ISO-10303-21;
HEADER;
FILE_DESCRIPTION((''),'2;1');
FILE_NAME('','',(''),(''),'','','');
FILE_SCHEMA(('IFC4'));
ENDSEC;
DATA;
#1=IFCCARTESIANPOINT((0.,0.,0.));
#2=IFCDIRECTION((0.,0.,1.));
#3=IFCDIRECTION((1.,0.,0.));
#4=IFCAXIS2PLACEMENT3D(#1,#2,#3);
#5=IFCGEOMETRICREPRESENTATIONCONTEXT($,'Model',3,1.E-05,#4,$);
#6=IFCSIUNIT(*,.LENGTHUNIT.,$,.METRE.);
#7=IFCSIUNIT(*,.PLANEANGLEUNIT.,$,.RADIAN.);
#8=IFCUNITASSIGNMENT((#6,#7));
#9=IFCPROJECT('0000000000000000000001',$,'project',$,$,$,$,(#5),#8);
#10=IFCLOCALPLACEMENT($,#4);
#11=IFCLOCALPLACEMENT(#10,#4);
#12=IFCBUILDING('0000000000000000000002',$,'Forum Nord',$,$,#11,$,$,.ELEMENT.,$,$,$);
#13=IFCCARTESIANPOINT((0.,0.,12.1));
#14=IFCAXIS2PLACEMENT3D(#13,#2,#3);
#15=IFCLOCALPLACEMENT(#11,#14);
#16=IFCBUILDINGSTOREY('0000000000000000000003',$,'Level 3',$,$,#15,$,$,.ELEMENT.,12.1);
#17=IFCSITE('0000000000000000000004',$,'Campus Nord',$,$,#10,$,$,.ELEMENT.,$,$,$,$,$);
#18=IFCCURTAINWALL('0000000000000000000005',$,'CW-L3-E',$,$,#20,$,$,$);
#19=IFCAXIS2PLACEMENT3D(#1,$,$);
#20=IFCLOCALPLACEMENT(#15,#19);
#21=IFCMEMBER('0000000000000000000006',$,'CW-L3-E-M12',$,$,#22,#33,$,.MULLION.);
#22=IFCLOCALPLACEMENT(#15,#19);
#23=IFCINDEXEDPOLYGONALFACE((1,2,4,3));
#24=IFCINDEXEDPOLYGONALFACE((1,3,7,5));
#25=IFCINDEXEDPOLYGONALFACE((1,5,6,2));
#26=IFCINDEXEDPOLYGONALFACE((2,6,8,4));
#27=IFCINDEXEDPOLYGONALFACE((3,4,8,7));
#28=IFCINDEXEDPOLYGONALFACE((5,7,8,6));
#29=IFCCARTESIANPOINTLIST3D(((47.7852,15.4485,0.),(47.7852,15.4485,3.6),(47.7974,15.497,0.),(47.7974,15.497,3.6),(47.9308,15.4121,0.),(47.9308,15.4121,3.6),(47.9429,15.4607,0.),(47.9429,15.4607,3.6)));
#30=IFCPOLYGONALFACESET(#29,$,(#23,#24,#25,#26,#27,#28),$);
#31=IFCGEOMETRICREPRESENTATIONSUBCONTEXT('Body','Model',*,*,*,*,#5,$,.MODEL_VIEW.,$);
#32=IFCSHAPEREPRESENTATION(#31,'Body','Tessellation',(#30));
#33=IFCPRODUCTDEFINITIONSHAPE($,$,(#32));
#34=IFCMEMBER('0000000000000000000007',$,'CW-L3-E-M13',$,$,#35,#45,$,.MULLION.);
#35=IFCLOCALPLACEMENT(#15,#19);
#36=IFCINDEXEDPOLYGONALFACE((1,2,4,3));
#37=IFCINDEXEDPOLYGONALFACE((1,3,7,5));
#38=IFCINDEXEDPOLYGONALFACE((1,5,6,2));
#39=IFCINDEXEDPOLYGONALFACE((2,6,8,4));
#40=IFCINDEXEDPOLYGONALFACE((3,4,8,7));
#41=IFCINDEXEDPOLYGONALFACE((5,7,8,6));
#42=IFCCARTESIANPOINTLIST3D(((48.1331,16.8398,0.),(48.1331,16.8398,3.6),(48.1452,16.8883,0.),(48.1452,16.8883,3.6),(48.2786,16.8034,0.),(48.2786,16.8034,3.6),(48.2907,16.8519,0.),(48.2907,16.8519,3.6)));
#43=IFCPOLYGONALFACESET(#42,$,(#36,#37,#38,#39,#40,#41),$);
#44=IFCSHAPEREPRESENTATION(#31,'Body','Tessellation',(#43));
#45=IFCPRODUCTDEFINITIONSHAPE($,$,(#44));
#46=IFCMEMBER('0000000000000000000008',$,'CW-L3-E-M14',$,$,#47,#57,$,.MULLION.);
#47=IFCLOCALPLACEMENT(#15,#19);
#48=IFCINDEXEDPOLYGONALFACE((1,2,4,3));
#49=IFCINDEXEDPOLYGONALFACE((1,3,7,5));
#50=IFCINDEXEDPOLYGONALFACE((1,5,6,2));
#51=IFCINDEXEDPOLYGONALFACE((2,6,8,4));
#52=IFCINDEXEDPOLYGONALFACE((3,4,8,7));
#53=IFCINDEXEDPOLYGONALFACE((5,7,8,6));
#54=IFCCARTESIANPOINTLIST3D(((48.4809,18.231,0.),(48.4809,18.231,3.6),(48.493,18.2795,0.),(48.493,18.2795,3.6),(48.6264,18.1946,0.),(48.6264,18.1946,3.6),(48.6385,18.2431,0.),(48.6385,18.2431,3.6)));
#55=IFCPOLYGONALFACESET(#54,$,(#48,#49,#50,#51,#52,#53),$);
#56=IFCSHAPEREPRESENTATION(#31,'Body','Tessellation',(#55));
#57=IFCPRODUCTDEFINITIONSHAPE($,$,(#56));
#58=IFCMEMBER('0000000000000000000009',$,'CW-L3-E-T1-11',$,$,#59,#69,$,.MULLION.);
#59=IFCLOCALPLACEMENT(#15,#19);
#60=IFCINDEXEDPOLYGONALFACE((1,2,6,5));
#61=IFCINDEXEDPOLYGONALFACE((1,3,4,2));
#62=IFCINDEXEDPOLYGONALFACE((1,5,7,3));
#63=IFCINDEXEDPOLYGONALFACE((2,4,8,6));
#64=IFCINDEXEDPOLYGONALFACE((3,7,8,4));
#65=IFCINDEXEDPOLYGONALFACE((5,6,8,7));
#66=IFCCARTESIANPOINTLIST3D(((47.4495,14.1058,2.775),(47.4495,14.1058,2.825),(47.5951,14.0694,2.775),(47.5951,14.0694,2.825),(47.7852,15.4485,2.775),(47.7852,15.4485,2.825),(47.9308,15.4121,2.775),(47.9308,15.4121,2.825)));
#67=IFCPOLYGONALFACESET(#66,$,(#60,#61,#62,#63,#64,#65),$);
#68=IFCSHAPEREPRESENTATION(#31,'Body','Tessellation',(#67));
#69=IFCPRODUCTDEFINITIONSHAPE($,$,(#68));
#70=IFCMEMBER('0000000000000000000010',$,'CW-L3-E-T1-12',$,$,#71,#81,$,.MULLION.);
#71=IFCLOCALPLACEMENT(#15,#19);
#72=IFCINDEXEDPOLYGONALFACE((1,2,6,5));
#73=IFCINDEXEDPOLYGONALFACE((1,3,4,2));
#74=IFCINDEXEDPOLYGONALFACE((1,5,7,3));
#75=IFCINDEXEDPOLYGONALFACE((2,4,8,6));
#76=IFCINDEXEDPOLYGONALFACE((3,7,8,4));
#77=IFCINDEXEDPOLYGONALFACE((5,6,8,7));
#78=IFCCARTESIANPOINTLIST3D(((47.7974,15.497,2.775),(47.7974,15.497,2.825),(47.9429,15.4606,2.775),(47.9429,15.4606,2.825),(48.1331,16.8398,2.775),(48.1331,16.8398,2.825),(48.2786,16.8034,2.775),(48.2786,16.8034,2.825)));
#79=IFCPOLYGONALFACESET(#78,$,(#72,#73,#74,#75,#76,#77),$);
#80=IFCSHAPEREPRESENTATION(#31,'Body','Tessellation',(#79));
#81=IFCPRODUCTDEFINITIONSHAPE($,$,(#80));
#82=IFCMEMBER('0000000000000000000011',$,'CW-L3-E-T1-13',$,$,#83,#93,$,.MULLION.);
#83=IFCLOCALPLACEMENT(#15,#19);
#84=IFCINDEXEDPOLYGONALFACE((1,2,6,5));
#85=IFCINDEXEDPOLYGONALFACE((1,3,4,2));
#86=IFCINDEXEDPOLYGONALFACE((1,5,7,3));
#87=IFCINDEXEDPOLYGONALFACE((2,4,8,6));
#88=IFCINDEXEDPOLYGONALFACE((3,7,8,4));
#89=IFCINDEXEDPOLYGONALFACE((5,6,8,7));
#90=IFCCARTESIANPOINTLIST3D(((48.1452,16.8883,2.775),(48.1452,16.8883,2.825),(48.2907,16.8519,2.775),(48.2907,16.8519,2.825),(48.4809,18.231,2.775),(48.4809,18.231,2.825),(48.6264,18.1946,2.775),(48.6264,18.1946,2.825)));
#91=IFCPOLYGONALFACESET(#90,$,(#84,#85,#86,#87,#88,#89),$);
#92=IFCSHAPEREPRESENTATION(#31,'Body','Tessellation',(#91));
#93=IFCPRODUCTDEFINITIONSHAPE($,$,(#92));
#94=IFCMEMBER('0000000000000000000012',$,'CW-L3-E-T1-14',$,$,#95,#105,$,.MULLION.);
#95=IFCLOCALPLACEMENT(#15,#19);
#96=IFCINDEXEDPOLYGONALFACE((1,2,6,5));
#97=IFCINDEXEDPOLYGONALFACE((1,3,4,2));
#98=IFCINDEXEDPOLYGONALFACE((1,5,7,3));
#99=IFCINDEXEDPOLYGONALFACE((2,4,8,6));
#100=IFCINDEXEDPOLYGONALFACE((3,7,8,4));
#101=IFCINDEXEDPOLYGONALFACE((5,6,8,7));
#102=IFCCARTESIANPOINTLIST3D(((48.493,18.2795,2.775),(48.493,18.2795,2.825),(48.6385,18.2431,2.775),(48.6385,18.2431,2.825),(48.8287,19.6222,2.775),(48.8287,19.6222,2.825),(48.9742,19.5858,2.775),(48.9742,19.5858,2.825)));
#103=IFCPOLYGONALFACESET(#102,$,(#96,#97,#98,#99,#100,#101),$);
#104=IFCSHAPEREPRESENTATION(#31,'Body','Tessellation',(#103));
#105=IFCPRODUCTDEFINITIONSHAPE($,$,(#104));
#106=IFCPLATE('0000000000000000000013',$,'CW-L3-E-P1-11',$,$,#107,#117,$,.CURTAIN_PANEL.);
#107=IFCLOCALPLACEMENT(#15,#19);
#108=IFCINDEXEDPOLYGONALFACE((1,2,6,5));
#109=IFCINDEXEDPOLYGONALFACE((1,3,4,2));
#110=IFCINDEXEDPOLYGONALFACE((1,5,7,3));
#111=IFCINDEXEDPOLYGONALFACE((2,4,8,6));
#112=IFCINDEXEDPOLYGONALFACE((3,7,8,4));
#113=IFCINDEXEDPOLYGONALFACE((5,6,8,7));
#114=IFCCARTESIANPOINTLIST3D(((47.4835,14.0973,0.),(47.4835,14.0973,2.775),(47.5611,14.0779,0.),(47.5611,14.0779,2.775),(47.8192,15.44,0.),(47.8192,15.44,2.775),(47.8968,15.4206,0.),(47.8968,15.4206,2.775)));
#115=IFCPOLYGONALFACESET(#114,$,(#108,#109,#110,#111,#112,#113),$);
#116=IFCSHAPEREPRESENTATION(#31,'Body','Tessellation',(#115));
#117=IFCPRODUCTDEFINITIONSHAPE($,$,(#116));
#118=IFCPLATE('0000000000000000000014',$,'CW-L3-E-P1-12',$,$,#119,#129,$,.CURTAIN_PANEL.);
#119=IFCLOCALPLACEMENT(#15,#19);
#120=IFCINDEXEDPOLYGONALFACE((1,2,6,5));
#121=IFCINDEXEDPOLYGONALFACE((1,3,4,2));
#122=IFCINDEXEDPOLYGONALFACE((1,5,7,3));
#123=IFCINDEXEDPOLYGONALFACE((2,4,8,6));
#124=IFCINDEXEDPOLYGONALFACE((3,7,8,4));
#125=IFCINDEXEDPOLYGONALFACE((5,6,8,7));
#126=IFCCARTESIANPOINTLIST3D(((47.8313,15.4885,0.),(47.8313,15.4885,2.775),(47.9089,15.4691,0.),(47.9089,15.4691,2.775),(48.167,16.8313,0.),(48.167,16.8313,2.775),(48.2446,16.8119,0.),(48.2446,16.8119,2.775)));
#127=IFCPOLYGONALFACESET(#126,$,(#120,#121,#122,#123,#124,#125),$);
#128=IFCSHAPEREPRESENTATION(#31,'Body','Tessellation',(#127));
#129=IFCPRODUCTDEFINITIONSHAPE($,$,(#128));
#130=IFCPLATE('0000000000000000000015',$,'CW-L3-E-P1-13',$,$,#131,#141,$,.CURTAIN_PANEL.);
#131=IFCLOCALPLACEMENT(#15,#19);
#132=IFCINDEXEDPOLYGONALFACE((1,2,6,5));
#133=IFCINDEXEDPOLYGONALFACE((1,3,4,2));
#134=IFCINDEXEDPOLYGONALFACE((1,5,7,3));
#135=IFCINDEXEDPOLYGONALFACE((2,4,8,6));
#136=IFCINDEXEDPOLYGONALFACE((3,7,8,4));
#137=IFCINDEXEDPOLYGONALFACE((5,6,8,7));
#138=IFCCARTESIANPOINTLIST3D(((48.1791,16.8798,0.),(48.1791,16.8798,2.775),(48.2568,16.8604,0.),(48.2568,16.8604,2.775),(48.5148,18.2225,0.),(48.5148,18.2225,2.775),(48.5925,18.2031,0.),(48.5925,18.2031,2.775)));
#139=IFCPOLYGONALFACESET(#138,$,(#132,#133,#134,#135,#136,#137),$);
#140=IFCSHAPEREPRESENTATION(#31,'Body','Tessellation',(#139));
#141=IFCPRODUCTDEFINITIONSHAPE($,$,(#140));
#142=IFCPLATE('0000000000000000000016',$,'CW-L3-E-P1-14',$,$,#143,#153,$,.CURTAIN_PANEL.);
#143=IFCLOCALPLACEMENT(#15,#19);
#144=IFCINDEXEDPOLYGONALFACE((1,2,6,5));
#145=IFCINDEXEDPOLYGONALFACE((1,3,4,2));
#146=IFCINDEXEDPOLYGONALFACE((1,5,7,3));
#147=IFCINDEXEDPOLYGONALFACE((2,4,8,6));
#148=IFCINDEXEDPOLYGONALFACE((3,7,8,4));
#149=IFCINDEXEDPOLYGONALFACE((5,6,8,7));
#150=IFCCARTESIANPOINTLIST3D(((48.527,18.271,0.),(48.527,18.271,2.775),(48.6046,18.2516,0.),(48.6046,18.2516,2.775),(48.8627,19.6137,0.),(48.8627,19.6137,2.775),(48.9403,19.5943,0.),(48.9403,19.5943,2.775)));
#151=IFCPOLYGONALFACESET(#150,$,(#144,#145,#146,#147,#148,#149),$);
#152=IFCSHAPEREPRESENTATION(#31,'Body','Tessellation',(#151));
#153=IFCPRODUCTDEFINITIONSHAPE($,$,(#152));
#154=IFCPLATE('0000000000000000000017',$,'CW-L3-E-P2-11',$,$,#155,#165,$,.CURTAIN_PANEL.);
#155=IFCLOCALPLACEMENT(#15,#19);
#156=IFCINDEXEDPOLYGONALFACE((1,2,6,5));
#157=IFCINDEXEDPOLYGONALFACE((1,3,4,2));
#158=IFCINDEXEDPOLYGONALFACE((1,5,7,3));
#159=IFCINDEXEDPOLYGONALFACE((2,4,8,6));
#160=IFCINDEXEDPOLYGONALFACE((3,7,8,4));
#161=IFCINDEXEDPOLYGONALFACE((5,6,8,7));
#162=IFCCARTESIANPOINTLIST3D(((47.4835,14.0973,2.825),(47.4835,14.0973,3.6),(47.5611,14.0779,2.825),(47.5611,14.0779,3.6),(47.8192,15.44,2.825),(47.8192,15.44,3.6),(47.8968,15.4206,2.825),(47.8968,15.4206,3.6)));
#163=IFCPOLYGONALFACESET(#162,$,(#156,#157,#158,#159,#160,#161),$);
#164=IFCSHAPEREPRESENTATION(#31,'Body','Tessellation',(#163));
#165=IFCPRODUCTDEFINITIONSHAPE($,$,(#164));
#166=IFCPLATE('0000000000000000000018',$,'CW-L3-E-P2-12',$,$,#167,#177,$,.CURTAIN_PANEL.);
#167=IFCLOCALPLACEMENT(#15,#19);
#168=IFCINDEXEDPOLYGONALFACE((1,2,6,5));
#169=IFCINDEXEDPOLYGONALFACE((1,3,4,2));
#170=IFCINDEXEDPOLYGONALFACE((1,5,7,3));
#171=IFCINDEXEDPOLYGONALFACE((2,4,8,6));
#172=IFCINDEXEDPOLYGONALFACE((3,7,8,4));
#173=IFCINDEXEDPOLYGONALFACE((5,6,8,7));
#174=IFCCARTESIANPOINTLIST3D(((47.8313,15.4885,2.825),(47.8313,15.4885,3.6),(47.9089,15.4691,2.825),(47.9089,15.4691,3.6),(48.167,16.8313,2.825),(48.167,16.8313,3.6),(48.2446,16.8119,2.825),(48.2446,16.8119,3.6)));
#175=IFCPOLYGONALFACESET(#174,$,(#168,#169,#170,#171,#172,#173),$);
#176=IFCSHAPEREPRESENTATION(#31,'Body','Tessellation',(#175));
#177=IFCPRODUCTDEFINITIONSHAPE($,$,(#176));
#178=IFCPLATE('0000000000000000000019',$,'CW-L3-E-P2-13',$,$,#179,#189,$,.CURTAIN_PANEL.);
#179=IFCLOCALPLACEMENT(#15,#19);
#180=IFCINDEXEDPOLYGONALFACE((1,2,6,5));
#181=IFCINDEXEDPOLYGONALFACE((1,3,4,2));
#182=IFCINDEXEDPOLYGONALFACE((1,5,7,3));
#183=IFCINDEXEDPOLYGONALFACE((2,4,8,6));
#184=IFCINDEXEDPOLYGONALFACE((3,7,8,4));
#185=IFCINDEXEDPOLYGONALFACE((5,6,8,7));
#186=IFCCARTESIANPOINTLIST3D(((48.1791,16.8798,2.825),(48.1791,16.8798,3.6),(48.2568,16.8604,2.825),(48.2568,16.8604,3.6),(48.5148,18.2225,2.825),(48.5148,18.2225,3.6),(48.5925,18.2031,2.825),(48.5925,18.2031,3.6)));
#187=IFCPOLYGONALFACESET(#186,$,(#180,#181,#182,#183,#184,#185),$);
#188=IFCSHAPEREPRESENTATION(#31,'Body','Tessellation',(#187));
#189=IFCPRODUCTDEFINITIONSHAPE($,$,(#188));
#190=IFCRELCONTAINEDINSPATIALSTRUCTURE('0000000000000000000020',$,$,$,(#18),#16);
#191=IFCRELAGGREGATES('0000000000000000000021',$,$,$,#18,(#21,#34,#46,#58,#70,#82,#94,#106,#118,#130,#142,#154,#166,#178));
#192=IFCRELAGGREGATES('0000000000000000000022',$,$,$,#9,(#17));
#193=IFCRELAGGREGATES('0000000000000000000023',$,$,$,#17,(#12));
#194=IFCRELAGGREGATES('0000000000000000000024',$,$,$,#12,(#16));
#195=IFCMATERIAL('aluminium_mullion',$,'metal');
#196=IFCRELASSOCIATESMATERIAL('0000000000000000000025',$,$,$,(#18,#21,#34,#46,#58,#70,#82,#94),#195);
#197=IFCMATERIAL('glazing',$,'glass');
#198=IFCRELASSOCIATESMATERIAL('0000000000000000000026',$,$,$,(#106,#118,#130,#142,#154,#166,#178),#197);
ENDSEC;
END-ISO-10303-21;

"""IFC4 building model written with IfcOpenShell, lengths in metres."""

from ifc_helpers import new_model, si_unit, frame, frame_2d, origin_with_axes, origin_2d_with_axis, place, context, subcontext, project, spatial, rectangle, extrude, material, element, aggregate, save


model = new_model("IFC4")

# Units and contexts
model_context = context("Model", 3, precision=1e-05, world=origin_with_axes())
body_context = subcontext(model_context, "Body", "Model", "MODEL_VIEW")
ifc_project = project(units=[si_unit("LENGTHUNIT", "METRE"), si_unit("PLANEANGLEUNIT", "RADIAN")], contexts=[model_context])

# Site, building, storey
site_placement = place(None, origin_with_axes())
site = spatial("IfcSite", under=ifc_project, at=site_placement, Name="Campus Nord", CompositionType="ELEMENT")
building_placement = place(site_placement, origin_with_axes())
building = spatial("IfcBuilding", under=site, at=building_placement, Name="Forum Nord", CompositionType="ELEMENT")
storey_placement = place(building_placement, frame((0.0, 0.0, 12.1), z_axis=(0.0, 0.0, 1.0), x_axis=(1.0, 0.0, 0.0)))
storey = spatial("IfcBuildingStorey", under=building, at=storey_placement, Name="Level 3", CompositionType="ELEMENT", Elevation=12.1)

# Curtain wall, members, plates
ifc_material_1 = material(Name="aluminium_mullion", Category="metal")
curtain_wall_placement = place(storey_placement, origin_with_axes())
curtain_wall = element("IfcCurtainWall", 1, at=curtain_wall_placement, inside=storey, material=ifc_material_1, Name="CW-L3-E")
member_1_placement = place(storey_placement, frame((47.8641, 15.4546, 0.0), z_axis=(0.0, 0.0, 1.0), x_axis=(0.24255, 0.97014, 0.0)))
member_1 = element("IfcMember", 2, at=member_1_placement, material=ifc_material_1, Name="CW-L3-E-M12", PredefinedType="MULLION", context=body_context, shape_type="SweptSolid", body=[
    extrude(rectangle(XDim=0.05, YDim=0.15, at=origin_2d_with_axis()), origin_with_axes(), (0.0, 0.0, 1.0), 3.6),
])
member_2_placement = place(storey_placement, frame((48.2119, 16.8458, 0.0), z_axis=(0.0, 0.0, 1.0), x_axis=(0.24255, 0.97014, 0.0)))
member_2 = element("IfcMember", 3, at=member_2_placement, material=ifc_material_1, Name="CW-L3-E-M13", PredefinedType="MULLION", context=body_context, shape_type="SweptSolid", body=[
    extrude(rectangle(XDim=0.05, YDim=0.15, at=origin_2d_with_axis()), origin_with_axes(), (0.0, 0.0, 1.0), 3.6),
])
member_3_placement = place(storey_placement, frame((48.5597, 18.2371, 0.0), z_axis=(0.0, 0.0, 1.0), x_axis=(0.24255, 0.97014, 0.0)))
member_3 = element("IfcMember", 4, at=member_3_placement, material=ifc_material_1, Name="CW-L3-E-M14", PredefinedType="MULLION", context=body_context, shape_type="SweptSolid", body=[
    extrude(rectangle(XDim=0.05, YDim=0.15, at=origin_2d_with_axis()), origin_with_axes(), (0.0, 0.0, 1.0), 3.6),
])
member_4_placement = place(storey_placement, frame((47.5223, 14.0876, 2.8), z_axis=(0.24255, 0.97014, 0.0), x_axis=(-0.97014, 0.24255, 0.0)))
member_4 = element("IfcMember", 5, at=member_4_placement, material=ifc_material_1, Name="CW-L3-E-T1-11", PredefinedType="MULLION", context=body_context, shape_type="SweptSolid", body=[
    extrude(rectangle(XDim=0.15, YDim=0.05, at=origin_2d_with_axis()), origin_with_axes(), (0.0, 0.0, 1.0), 1.3841),
])
member_5_placement = place(storey_placement, frame((47.8701, 15.4788, 2.8), z_axis=(0.24255, 0.97014, 0.0), x_axis=(-0.97014, 0.24255, 0.0)))
member_5 = element("IfcMember", 6, at=member_5_placement, material=ifc_material_1, Name="CW-L3-E-T1-12", PredefinedType="MULLION", context=body_context, shape_type="SweptSolid", body=[
    extrude(rectangle(XDim=0.15, YDim=0.05, at=origin_2d_with_axis()), origin_with_axes(), (0.0, 0.0, 1.0), 1.3841),
])
member_6_placement = place(storey_placement, frame((48.218, 16.8701, 2.8), z_axis=(0.24255, 0.97014, 0.0), x_axis=(-0.97014, 0.24255, 0.0)))
member_6 = element("IfcMember", 7, at=member_6_placement, material=ifc_material_1, Name="CW-L3-E-T1-13", PredefinedType="MULLION", context=body_context, shape_type="SweptSolid", body=[
    extrude(rectangle(XDim=0.15, YDim=0.05, at=origin_2d_with_axis()), origin_with_axes(), (0.0, 0.0, 1.0), 1.3841),
])
member_7_placement = place(storey_placement, frame((48.5658, 18.2613, 2.8), z_axis=(0.24255, 0.97014, 0.0), x_axis=(-0.97014, 0.24255, 0.0)))
member_7 = element("IfcMember", 8, at=member_7_placement, material=ifc_material_1, Name="CW-L3-E-T1-14", PredefinedType="MULLION", context=body_context, shape_type="SweptSolid", body=[
    extrude(rectangle(XDim=0.15, YDim=0.05, at=origin_2d_with_axis()), origin_with_axes(), (0.0, 0.0, 1.0), 1.3841),
])
ifc_material_2 = material(Name="glazing", Category="glass")
plate_1_placement = place(storey_placement, frame((47.5223, 14.0876, 0.0), z_axis=(0.0, 0.0, 1.0), x_axis=(0.24255, 0.97014, 0.0)))
plate_1 = element("IfcPlate", 9, at=plate_1_placement, material=ifc_material_2, Name="CW-L3-E-P1-11", PredefinedType="CURTAIN_PANEL", context=body_context, shape_type="SweptSolid", body=[
    extrude(rectangle(XDim=1.3841, YDim=0.08, at=frame_2d((0.692, 0.0), x_axis=(1.0, 0.0))), origin_with_axes(), (0.0, 0.0, 1.0), 2.775),
])
plate_2_placement = place(storey_placement, frame((47.8701, 15.4788, 0.0), z_axis=(0.0, 0.0, 1.0), x_axis=(0.24255, 0.97014, 0.0)))
plate_2 = element("IfcPlate", 10, at=plate_2_placement, material=ifc_material_2, Name="CW-L3-E-P1-12", PredefinedType="CURTAIN_PANEL", context=body_context, shape_type="SweptSolid", body=[
    extrude(rectangle(XDim=1.3841, YDim=0.08, at=frame_2d((0.692, 0.0), x_axis=(1.0, 0.0))), origin_with_axes(), (0.0, 0.0, 1.0), 2.775),
])
plate_3_placement = place(storey_placement, frame((48.218, 16.8701, 0.0), z_axis=(0.0, 0.0, 1.0), x_axis=(0.24255, 0.97014, 0.0)))
plate_3 = element("IfcPlate", 11, at=plate_3_placement, material=ifc_material_2, Name="CW-L3-E-P1-13", PredefinedType="CURTAIN_PANEL", context=body_context, shape_type="SweptSolid", body=[
    extrude(rectangle(XDim=1.3841, YDim=0.08, at=frame_2d((0.692, 0.0), x_axis=(1.0, 0.0))), origin_with_axes(), (0.0, 0.0, 1.0), 2.775),
])
plate_4_placement = place(storey_placement, frame((48.5658, 18.2613, 0.0), z_axis=(0.0, 0.0, 1.0), x_axis=(0.24255, 0.97014, 0.0)))
plate_4 = element("IfcPlate", 12, at=plate_4_placement, material=ifc_material_2, Name="CW-L3-E-P1-14", PredefinedType="CURTAIN_PANEL", context=body_context, shape_type="SweptSolid", body=[
    extrude(rectangle(XDim=1.3841, YDim=0.08, at=frame_2d((0.692, 0.0), x_axis=(1.0, 0.0))), origin_with_axes(), (0.0, 0.0, 1.0), 2.775),
])
plate_5_placement = place(storey_placement, frame((47.5223, 14.0876, 2.825), z_axis=(0.0, 0.0, 1.0), x_axis=(0.24255, 0.97014, 0.0)))
plate_5 = element("IfcPlate", 13, at=plate_5_placement, material=ifc_material_2, Name="CW-L3-E-P2-11", PredefinedType="CURTAIN_PANEL", context=body_context, shape_type="SweptSolid", body=[
    extrude(rectangle(XDim=1.3841, YDim=0.08, at=frame_2d((0.692, 0.0), x_axis=(1.0, 0.0))), origin_with_axes(), (0.0, 0.0, 1.0), 0.775),
])
plate_6_placement = place(storey_placement, frame((47.8701, 15.4788, 2.825), z_axis=(0.0, 0.0, 1.0), x_axis=(0.24255, 0.97014, 0.0)))
plate_6 = element("IfcPlate", 14, at=plate_6_placement, material=ifc_material_2, Name="CW-L3-E-P2-12", PredefinedType="CURTAIN_PANEL", context=body_context, shape_type="SweptSolid", body=[
    extrude(rectangle(XDim=1.3841, YDim=0.08, at=frame_2d((0.692, 0.0), x_axis=(1.0, 0.0))), origin_with_axes(), (0.0, 0.0, 1.0), 0.775),
])
plate_7_placement = place(storey_placement, frame((48.218, 16.8701, 2.825), z_axis=(0.0, 0.0, 1.0), x_axis=(0.24255, 0.97014, 0.0)))
plate_7 = element("IfcPlate", 15, at=plate_7_placement, material=ifc_material_2, Name="CW-L3-E-P2-13", PredefinedType="CURTAIN_PANEL", context=body_context, shape_type="SweptSolid", body=[
    extrude(rectangle(XDim=1.3841, YDim=0.08, at=frame_2d((0.692, 0.0), x_axis=(1.0, 0.0))), origin_with_axes(), (0.0, 0.0, 1.0), 0.775),
])
aggregate(curtain_wall, [member_1, member_2, member_3, member_4, member_5, member_6, member_7, plate_1, plate_2, plate_3, plate_4, plate_5, plate_6, plate_7])

save(model, "model.ifc")
